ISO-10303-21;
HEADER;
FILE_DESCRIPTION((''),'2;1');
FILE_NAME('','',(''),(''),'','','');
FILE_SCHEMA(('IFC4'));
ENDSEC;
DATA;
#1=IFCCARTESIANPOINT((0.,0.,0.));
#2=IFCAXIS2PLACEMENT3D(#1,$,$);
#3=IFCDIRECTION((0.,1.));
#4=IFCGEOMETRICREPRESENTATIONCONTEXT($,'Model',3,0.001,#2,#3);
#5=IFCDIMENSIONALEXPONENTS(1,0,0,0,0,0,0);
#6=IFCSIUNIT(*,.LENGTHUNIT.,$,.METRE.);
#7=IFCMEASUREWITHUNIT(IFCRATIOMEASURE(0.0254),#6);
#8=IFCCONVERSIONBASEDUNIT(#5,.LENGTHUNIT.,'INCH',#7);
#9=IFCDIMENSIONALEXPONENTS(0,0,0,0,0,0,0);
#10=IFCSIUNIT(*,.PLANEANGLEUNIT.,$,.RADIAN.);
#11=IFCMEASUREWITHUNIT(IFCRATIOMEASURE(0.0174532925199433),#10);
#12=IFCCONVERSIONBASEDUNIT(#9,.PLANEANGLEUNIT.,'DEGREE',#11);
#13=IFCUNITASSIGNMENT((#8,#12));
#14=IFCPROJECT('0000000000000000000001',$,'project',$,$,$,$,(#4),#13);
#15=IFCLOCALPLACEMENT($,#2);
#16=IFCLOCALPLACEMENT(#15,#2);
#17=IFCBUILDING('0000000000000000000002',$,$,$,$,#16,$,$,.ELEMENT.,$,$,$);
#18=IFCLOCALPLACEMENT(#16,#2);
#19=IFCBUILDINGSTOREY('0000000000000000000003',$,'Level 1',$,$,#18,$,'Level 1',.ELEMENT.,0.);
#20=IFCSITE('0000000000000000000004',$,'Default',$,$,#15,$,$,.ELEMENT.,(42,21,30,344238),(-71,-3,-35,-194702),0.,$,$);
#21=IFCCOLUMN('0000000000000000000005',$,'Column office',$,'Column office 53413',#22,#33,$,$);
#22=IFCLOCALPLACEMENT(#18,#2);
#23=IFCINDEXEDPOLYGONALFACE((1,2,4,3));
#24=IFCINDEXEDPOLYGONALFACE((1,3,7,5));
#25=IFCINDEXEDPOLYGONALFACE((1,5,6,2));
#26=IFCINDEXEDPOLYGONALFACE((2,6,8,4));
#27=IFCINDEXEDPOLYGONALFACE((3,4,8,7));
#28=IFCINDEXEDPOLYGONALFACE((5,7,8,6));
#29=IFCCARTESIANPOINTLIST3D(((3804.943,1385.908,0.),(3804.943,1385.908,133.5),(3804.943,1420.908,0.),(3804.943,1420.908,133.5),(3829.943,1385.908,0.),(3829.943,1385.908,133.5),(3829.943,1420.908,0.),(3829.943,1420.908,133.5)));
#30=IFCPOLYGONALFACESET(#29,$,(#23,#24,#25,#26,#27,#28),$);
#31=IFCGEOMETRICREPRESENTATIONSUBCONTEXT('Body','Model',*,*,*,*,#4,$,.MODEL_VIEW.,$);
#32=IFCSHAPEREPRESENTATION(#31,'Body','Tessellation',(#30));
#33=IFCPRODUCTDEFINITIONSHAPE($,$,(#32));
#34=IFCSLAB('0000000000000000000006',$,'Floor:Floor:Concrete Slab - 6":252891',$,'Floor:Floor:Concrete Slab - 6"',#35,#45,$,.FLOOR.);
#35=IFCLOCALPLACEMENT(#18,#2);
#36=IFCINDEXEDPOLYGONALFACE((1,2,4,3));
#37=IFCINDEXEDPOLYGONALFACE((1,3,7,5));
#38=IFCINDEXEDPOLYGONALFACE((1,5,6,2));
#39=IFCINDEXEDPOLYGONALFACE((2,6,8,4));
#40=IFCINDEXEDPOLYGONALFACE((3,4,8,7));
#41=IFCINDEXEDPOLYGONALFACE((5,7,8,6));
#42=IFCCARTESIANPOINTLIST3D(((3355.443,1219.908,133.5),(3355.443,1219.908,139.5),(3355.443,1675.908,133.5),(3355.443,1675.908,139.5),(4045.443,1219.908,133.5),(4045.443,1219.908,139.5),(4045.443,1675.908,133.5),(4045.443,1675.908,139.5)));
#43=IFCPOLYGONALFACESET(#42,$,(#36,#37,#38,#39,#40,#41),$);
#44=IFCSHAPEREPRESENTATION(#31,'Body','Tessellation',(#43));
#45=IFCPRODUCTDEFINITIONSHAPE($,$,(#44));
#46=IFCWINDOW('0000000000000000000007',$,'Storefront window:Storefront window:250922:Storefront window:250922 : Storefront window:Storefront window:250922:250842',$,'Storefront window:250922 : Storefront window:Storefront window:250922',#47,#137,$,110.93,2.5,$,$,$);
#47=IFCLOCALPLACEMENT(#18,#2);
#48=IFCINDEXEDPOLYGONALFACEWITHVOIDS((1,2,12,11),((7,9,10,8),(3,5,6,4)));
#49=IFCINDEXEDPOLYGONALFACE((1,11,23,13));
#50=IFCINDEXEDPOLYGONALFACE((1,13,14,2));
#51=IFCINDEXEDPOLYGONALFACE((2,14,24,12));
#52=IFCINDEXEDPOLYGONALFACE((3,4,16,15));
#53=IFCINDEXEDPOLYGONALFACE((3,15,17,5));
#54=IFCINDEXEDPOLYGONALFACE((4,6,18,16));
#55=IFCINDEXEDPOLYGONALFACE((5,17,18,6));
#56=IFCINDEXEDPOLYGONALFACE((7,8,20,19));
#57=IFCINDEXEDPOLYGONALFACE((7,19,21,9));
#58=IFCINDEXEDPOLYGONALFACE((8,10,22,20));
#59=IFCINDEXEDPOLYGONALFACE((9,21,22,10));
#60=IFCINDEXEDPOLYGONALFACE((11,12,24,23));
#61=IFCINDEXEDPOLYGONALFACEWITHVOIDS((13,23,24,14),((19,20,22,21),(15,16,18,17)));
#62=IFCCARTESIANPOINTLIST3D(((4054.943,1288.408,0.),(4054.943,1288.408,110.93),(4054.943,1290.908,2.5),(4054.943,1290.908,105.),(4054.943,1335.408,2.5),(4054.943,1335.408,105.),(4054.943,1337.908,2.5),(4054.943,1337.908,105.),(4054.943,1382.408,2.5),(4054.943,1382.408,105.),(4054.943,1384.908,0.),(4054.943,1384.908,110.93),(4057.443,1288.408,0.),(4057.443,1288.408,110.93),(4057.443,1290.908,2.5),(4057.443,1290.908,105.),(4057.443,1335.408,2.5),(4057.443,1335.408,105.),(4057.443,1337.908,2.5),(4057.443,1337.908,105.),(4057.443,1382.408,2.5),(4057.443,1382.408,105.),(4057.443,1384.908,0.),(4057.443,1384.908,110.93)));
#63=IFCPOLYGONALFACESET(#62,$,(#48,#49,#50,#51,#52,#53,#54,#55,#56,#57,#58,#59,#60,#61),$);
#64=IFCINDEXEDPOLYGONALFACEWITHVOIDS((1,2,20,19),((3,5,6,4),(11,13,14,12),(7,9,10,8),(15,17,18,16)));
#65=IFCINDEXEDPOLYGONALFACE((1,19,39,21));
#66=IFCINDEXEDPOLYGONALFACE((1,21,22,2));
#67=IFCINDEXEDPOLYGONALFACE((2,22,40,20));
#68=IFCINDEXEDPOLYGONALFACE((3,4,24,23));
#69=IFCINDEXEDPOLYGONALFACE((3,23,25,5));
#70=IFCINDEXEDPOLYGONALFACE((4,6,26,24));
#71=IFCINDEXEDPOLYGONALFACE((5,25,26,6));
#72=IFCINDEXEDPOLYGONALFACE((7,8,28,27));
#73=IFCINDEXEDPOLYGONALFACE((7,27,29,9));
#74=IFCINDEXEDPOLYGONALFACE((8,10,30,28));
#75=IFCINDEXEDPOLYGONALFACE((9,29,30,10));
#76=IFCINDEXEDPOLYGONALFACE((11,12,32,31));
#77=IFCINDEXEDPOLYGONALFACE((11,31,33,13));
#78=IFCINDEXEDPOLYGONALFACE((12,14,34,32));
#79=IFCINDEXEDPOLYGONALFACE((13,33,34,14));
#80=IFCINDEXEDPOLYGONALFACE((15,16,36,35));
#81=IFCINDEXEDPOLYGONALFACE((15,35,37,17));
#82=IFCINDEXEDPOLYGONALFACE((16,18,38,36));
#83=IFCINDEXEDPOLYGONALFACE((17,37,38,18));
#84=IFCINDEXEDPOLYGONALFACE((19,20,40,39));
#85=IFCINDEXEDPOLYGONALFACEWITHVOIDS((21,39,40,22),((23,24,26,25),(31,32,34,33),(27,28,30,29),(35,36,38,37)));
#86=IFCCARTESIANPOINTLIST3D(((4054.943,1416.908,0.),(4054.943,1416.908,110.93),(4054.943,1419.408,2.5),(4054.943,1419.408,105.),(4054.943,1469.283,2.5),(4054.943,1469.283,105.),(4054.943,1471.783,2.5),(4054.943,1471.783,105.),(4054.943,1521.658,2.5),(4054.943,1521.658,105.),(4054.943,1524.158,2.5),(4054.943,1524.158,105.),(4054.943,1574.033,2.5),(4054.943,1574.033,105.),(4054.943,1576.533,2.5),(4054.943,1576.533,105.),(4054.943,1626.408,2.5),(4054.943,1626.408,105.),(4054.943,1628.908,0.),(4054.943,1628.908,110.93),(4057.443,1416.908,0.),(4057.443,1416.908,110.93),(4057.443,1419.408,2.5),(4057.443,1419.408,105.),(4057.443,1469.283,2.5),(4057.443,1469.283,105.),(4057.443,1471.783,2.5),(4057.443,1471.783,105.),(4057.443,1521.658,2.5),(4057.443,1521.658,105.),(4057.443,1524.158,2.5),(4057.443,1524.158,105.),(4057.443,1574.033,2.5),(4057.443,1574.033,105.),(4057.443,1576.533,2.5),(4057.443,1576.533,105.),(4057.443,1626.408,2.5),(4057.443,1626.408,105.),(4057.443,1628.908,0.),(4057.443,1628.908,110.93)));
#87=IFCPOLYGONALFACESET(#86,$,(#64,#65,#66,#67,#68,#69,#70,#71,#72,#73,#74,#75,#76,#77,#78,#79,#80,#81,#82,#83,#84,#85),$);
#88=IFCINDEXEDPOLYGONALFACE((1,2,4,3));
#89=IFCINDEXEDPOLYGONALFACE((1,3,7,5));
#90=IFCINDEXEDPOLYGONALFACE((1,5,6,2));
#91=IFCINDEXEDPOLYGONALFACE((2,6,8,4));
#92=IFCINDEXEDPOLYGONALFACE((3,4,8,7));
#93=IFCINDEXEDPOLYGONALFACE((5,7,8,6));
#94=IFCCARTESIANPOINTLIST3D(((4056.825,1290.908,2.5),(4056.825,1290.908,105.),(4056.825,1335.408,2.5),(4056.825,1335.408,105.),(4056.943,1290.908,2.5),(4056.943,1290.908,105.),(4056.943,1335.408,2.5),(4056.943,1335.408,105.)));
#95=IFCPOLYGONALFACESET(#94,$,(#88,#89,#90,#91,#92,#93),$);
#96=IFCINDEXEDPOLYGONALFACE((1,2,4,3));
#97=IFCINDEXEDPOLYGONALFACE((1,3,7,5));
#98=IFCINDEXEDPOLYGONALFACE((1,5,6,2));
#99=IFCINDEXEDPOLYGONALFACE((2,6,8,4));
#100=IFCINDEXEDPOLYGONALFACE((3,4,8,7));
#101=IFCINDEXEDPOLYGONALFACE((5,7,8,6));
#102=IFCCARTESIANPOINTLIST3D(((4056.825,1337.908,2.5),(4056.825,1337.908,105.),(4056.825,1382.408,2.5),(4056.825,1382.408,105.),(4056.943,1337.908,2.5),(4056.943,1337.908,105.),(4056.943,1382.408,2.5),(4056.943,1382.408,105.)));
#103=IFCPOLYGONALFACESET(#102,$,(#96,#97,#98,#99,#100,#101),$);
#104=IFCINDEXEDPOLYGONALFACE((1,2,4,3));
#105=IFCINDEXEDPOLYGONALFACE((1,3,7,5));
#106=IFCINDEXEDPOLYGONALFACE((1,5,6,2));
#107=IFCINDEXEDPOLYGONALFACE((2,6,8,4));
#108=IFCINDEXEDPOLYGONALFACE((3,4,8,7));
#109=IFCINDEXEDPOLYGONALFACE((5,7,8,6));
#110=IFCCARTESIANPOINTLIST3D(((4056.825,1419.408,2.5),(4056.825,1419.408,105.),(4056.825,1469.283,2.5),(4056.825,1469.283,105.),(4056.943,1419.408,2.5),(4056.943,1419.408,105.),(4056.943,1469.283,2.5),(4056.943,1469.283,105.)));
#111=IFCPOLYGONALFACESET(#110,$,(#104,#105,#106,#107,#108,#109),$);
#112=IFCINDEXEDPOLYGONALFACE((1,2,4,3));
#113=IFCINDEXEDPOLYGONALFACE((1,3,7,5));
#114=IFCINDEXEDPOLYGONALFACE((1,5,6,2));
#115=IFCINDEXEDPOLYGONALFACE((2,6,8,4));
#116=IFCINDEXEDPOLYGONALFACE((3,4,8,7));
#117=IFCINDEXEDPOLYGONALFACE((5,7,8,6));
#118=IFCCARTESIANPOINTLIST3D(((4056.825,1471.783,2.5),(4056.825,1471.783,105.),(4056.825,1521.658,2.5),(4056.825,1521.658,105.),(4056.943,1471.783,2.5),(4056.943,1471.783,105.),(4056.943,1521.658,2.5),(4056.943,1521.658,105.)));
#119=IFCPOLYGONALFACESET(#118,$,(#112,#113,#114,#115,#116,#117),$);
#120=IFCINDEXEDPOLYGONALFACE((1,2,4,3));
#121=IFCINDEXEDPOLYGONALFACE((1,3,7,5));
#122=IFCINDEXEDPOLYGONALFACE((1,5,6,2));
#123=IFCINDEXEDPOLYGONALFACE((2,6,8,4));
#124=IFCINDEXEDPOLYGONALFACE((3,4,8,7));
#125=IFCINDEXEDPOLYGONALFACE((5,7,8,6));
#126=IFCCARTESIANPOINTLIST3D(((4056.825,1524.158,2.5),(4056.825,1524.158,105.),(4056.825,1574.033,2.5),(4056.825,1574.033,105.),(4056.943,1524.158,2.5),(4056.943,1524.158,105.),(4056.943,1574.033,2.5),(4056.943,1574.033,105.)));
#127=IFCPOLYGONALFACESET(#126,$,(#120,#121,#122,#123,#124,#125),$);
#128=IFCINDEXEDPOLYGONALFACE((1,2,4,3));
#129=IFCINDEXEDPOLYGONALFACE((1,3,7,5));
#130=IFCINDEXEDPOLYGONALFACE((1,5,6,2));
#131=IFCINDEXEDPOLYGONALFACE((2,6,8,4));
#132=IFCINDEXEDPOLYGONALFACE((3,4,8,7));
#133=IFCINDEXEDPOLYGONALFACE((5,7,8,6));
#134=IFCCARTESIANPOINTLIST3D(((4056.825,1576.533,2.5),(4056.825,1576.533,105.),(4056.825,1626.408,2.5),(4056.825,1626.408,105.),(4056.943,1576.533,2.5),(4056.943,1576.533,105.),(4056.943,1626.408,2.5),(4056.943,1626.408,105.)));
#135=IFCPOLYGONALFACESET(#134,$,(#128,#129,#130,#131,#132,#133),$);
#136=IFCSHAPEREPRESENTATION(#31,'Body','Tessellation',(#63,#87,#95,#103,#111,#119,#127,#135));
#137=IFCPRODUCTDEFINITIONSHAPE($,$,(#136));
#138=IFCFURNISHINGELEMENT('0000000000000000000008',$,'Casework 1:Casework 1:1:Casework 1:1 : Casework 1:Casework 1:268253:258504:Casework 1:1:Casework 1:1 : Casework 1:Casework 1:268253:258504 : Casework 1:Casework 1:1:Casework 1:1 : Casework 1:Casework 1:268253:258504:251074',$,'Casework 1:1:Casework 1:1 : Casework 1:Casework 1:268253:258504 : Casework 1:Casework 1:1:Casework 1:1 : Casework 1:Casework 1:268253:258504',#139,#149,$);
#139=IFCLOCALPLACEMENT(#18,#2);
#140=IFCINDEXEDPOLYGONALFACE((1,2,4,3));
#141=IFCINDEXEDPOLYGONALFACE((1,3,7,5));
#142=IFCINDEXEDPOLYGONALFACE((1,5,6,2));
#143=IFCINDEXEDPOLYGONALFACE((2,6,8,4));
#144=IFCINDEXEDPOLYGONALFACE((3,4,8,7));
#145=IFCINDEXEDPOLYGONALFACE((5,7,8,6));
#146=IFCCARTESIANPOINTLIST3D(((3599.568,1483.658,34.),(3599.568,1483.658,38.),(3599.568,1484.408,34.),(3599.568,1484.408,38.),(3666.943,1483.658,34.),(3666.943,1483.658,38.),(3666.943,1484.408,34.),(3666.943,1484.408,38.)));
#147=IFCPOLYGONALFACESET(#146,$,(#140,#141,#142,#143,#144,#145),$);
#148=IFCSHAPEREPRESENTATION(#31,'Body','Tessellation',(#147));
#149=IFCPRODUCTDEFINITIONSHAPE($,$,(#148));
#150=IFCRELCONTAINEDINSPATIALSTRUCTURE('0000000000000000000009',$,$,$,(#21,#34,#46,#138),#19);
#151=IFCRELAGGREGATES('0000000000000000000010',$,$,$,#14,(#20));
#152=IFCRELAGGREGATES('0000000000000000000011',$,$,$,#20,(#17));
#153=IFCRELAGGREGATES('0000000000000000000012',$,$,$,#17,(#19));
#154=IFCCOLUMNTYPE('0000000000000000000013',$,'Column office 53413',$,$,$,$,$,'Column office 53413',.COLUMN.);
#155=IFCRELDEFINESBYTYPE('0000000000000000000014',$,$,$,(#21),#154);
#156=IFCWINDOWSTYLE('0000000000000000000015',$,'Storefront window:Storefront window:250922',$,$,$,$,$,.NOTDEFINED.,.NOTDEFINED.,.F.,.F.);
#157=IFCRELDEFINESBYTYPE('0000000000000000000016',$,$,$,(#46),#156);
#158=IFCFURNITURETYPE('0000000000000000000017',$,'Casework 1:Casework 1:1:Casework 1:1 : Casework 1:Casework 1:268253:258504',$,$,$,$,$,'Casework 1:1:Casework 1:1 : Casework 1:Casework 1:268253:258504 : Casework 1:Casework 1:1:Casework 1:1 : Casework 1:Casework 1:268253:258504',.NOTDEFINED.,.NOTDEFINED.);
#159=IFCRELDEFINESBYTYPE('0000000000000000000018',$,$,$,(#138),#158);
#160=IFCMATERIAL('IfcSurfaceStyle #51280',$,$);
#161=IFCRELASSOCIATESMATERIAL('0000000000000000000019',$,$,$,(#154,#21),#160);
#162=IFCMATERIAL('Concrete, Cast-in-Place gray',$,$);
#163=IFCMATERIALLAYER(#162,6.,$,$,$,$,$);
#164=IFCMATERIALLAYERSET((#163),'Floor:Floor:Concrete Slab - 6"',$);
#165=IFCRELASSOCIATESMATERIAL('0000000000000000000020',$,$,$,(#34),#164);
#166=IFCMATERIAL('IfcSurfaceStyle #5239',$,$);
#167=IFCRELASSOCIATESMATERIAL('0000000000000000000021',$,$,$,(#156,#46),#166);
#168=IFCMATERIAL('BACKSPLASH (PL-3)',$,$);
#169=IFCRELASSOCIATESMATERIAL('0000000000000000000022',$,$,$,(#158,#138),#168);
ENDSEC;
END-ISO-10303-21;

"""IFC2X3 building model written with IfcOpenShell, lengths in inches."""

from ifc_helpers import new_model, entity, si_unit, converted_unit, direction, frame, frame_2d, origin, origin_2d_with_axis, place, context, subcontext, project, spatial, polyline, rectangle, outline, extrude, source, transform, mapped, material, layer, layer_set, layer_usage, type_object, type_shapes, element, save


model = new_model("IFC2X3")

# Units and contexts
model_context = context("Model", 3, precision=0.001, world=origin(), true_north=direction((0.0, 1.0)))
body_context = subcontext(model_context, "Body", "Model", "MODEL_VIEW")
ifc_project = project(units=[converted_unit("LENGTHUNIT", "INCH", entity("IfcRatioMeasure", 0.0254), si_unit("LENGTHUNIT", "METRE"), dimensions=[1, 0, 0, 0, 0, 0, 0]), converted_unit("PLANEANGLEUNIT", "DEGREE", entity("IfcRatioMeasure", 0.0174532925199433), si_unit("PLANEANGLEUNIT", "RADIAN"), dimensions=[0, 0, 0, 0, 0, 0, 0])], contexts=[model_context])

# Site, building, storey
site_placement = place(None, origin())
site = spatial("IfcSite", under=ifc_project, at=site_placement, Name="Default", CompositionType="ELEMENT", RefLatitude=(42, 21, 30, 344238), RefLongitude=(-71, -3, -35, -194702), RefElevation=0.0)
building_placement = place(site_placement, origin())
building = spatial("IfcBuilding", under=site, at=building_placement, CompositionType="ELEMENT")
storey_placement = place(building_placement, origin())
storey = spatial("IfcBuildingStorey", under=building, at=storey_placement, Name="Level 1", LongName="Level 1", CompositionType="ELEMENT", Elevation=0.0)

# Column
ifc_material_1 = material(Name="IfcSurfaceStyle #51280")
column_type = type_object("IfcColumnType", Name="Column office 53413", ElementType="Column office 53413", PredefinedType="COLUMN", material=ifc_material_1)
shared_shape_1 = source(origin(), body_context, "Body", "SweptSolid", [
    extrude(rectangle(XDim=35.0, YDim=25.0, at=frame_2d((0.0, 0.0), x_axis=(1.0, 0.0))), frame((3817.443, 1403.408, 0.0), z_axis=(0.0, 0.0, 1.0), x_axis=(0.0, -1.0, 0.0)), (0.0, 0.0, 1.0), 133.5),
])
type_shapes(column_type, [shared_shape_1])
column_placement = place(storey_placement, origin())
element("IfcColumn", 1, at=column_placement, inside=storey, type_object=column_type, material=ifc_material_1, Name="Column office", ObjectType="Column office 53413", context=body_context, shape_type="MappedRepresentation", body=[
    mapped(shared_shape_1, transform((0.0, 0.0, 0.0), scale=1.0)),
])

# Slab
ifc_material_2 = material(Name="Concrete, Cast-in-Place gray")
ifc_layer = layer(ifc_material_2, 6.0)
ifc_layer_set = layer_set([ifc_layer], Name="Floor:Floor:Concrete Slab - 6\"")
ifc_layer_usage = layer_usage(ifc_layer_set, "AXIS3", "POSITIVE", 0.0)
slab_placement = place(storey_placement, origin())
element("IfcSlab", 2, at=slab_placement, inside=storey, material=ifc_layer_usage, Name="Floor:Floor:Concrete Slab - 6\":252891", ObjectType="Floor:Floor:Concrete Slab - 6\"", PredefinedType="FLOOR", context=body_context, shape_type="SweptSolid", body=[
    extrude(rectangle(XDim=456.0, YDim=690.0, at=frame_2d((0.0, 0.0), x_axis=(1.0, 0.0))), frame((3700.443, 1447.908, 139.5), z_axis=(0.0, 0.0, -1.0), x_axis=(0.0, 1.0, 0.0)), (0.0, 0.0, 1.0), 6.0),
])

# Window
ifc_material_3 = material(Name="IfcSurfaceStyle #5239")
window_style = type_object("IfcWindowStyle", Name="Storefront window:Storefront window:250922", ConstructionType="NOTDEFINED", OperationType="NOTDEFINED", ParameterTakesPrecedence=False, Sizeable=False, material=ifc_material_3)
shared_shape_2 = source(origin(), body_context, "Body", "SweptSolid", [
    extrude(outline(polyline([(-48.25, -55.465), (48.25, -55.465), (48.25, 55.465), (-48.25, 55.465), (-48.25, -55.465)]), holes=[polyline([(45.75, 49.535), (45.75, -52.965), (1.25, -52.965), (1.25, 49.535), (45.75, 49.535)]), polyline([(-1.25, 49.535), (-1.25, -52.965), (-45.75, -52.965), (-45.75, 49.535), (-1.25, 49.535)])]), frame((4054.943, 1336.658, 55.465), z_axis=(1.0, 0.0, 0.0), x_axis=(0.0, 1.0, 0.0)), (0.0, 0.0, 1.0), 2.5),
    extrude(outline(polyline([(-106.0, -55.465), (106.0, -55.465), (106.0, 55.465), (-106.0, 55.465), (-106.0, -55.465)]), holes=[polyline([(103.5, 49.535), (103.5, -52.965), (53.625, -52.965), (53.625, 49.535), (103.5, 49.535)]), polyline([(1.25, 49.535), (51.125, 49.535), (51.125, -52.965), (1.25, -52.965), (1.25, 49.535)]), polyline([(-1.25, -52.965), (-51.125, -52.965), (-51.125, 49.535), (-1.25, 49.535), (-1.25, -52.965)]), polyline([(-53.625, 49.535), (-53.625, -52.965), (-103.5, -52.965), (-103.5, 49.535), (-53.625, 49.535)])]), frame((4054.943, 1522.908, 55.465), z_axis=(1.0, 0.0, 0.0), x_axis=(0.0, 1.0, 0.0)), (0.0, 0.0, 1.0), 2.5),
    extrude(rectangle(XDim=44.5, YDim=0.118, at=origin_2d_with_axis()), frame((4056.884, 1313.158, 2.5), z_axis=(0.0, 0.0, 1.0), x_axis=(0.0, -1.0, 0.0)), (0.0, 0.0, 1.0), 102.5),
    extrude(rectangle(XDim=44.5, YDim=0.118, at=frame_2d((0.0, 0.0), x_axis=(1.0, 0.0))), frame((4056.884, 1360.158, 2.5), z_axis=(0.0, 0.0, 1.0), x_axis=(0.0, -1.0, 0.0)), (0.0, 0.0, 1.0), 102.5),
    extrude(rectangle(XDim=49.875, YDim=0.118, at=origin_2d_with_axis()), frame((4056.884, 1444.345, 2.5), z_axis=(0.0, 0.0, 1.0), x_axis=(0.0, -1.0, 0.0)), (0.0, 0.0, 1.0), 102.5),
    extrude(rectangle(XDim=49.875, YDim=0.118, at=origin_2d_with_axis()), frame((4056.884, 1496.72, 2.5), z_axis=(0.0, 0.0, 1.0), x_axis=(0.0, -1.0, 0.0)), (0.0, 0.0, 1.0), 102.5),
    extrude(rectangle(XDim=49.875, YDim=0.118, at=frame_2d((0.0, 0.0), x_axis=(1.0, 0.0))), frame((4056.884, 1549.095, 2.5), z_axis=(0.0, 0.0, 1.0), x_axis=(0.0, -1.0, 0.0)), (0.0, 0.0, 1.0), 102.5),
    extrude(rectangle(XDim=49.875, YDim=0.118, at=frame_2d((0.0, 0.0), x_axis=(1.0, 0.0))), frame((4056.884, 1601.47, 2.5), z_axis=(0.0, 0.0, 1.0), x_axis=(0.0, -1.0, 0.0)), (0.0, 0.0, 1.0), 102.5),
])
type_shapes(window_style, [shared_shape_2])
window_placement = place(storey_placement, origin())
element("IfcWindow", 3, at=window_placement, inside=storey, type_object=window_style, material=ifc_material_3, Name="Storefront window:Storefront window:250922:Storefront window:250922 : Storefront window:Storefront window:250922:250842", ObjectType="Storefront window:250922 : Storefront window:Storefront window:250922", OverallHeight=110.93, OverallWidth=2.5, context=body_context, shape_type="MappedRepresentation", body=[
    mapped(shared_shape_2, transform((0.0, 0.0, 0.0), scale=1.0)),
])

# Furnishing element
ifc_material_4 = material(Name="BACKSPLASH (PL-3)")
furniture_type_1 = type_object("IfcFurnitureType", Name="Casework 1:Casework 1:1:Casework 1:1 : Casework 1:Casework 1:268253:258504", ElementType="Casework 1:1:Casework 1:1 : Casework 1:Casework 1:268253:258504 : Casework 1:Casework 1:1:Casework 1:1 : Casework 1:Casework 1:268253:258504", AssemblyPlace="NOTDEFINED", material=ifc_material_4)
shared_shape_3 = source(origin(), body_context, "Body", "SweptSolid", [
    extrude(rectangle(XDim=0.75, YDim=67.375, at=origin_2d_with_axis()), frame((3633.256, 1484.033, 34.0), z_axis=(0.0, 0.0, 1.0), x_axis=(0.0, -1.0, 0.0)), (0.0, 0.0, 1.0), 4.0),
])
type_shapes(furniture_type_1, [shared_shape_3])
furnishing_1_placement = place(storey_placement, origin())
element("IfcFurnishingElement", 4, at=furnishing_1_placement, inside=storey, type_object=furniture_type_1, material=ifc_material_4, Name="Casework 1:Casework 1:1:Casework 1:1 : Casework 1:Casework 1:268253:258504:Casework 1:1:Casework 1:1 : Casework 1:Casework 1:268253:258504 : Casework 1:Casework 1:1:Casework 1:1 : Casework 1:Casework 1:268253:258504:251074", ObjectType="Casework 1:1:Casework 1:1 : Casework 1:Casework 1:268253:258504 : Casework 1:Casework 1:1:Casework 1:1 : Casework 1:Casework 1:268253:258504", context=body_context, shape_type="MappedRepresentation", body=[
    mapped(shared_shape_3, transform((0.0, 0.0, 0.0), scale=1.0)),
])

save(model, "model.ifc")
